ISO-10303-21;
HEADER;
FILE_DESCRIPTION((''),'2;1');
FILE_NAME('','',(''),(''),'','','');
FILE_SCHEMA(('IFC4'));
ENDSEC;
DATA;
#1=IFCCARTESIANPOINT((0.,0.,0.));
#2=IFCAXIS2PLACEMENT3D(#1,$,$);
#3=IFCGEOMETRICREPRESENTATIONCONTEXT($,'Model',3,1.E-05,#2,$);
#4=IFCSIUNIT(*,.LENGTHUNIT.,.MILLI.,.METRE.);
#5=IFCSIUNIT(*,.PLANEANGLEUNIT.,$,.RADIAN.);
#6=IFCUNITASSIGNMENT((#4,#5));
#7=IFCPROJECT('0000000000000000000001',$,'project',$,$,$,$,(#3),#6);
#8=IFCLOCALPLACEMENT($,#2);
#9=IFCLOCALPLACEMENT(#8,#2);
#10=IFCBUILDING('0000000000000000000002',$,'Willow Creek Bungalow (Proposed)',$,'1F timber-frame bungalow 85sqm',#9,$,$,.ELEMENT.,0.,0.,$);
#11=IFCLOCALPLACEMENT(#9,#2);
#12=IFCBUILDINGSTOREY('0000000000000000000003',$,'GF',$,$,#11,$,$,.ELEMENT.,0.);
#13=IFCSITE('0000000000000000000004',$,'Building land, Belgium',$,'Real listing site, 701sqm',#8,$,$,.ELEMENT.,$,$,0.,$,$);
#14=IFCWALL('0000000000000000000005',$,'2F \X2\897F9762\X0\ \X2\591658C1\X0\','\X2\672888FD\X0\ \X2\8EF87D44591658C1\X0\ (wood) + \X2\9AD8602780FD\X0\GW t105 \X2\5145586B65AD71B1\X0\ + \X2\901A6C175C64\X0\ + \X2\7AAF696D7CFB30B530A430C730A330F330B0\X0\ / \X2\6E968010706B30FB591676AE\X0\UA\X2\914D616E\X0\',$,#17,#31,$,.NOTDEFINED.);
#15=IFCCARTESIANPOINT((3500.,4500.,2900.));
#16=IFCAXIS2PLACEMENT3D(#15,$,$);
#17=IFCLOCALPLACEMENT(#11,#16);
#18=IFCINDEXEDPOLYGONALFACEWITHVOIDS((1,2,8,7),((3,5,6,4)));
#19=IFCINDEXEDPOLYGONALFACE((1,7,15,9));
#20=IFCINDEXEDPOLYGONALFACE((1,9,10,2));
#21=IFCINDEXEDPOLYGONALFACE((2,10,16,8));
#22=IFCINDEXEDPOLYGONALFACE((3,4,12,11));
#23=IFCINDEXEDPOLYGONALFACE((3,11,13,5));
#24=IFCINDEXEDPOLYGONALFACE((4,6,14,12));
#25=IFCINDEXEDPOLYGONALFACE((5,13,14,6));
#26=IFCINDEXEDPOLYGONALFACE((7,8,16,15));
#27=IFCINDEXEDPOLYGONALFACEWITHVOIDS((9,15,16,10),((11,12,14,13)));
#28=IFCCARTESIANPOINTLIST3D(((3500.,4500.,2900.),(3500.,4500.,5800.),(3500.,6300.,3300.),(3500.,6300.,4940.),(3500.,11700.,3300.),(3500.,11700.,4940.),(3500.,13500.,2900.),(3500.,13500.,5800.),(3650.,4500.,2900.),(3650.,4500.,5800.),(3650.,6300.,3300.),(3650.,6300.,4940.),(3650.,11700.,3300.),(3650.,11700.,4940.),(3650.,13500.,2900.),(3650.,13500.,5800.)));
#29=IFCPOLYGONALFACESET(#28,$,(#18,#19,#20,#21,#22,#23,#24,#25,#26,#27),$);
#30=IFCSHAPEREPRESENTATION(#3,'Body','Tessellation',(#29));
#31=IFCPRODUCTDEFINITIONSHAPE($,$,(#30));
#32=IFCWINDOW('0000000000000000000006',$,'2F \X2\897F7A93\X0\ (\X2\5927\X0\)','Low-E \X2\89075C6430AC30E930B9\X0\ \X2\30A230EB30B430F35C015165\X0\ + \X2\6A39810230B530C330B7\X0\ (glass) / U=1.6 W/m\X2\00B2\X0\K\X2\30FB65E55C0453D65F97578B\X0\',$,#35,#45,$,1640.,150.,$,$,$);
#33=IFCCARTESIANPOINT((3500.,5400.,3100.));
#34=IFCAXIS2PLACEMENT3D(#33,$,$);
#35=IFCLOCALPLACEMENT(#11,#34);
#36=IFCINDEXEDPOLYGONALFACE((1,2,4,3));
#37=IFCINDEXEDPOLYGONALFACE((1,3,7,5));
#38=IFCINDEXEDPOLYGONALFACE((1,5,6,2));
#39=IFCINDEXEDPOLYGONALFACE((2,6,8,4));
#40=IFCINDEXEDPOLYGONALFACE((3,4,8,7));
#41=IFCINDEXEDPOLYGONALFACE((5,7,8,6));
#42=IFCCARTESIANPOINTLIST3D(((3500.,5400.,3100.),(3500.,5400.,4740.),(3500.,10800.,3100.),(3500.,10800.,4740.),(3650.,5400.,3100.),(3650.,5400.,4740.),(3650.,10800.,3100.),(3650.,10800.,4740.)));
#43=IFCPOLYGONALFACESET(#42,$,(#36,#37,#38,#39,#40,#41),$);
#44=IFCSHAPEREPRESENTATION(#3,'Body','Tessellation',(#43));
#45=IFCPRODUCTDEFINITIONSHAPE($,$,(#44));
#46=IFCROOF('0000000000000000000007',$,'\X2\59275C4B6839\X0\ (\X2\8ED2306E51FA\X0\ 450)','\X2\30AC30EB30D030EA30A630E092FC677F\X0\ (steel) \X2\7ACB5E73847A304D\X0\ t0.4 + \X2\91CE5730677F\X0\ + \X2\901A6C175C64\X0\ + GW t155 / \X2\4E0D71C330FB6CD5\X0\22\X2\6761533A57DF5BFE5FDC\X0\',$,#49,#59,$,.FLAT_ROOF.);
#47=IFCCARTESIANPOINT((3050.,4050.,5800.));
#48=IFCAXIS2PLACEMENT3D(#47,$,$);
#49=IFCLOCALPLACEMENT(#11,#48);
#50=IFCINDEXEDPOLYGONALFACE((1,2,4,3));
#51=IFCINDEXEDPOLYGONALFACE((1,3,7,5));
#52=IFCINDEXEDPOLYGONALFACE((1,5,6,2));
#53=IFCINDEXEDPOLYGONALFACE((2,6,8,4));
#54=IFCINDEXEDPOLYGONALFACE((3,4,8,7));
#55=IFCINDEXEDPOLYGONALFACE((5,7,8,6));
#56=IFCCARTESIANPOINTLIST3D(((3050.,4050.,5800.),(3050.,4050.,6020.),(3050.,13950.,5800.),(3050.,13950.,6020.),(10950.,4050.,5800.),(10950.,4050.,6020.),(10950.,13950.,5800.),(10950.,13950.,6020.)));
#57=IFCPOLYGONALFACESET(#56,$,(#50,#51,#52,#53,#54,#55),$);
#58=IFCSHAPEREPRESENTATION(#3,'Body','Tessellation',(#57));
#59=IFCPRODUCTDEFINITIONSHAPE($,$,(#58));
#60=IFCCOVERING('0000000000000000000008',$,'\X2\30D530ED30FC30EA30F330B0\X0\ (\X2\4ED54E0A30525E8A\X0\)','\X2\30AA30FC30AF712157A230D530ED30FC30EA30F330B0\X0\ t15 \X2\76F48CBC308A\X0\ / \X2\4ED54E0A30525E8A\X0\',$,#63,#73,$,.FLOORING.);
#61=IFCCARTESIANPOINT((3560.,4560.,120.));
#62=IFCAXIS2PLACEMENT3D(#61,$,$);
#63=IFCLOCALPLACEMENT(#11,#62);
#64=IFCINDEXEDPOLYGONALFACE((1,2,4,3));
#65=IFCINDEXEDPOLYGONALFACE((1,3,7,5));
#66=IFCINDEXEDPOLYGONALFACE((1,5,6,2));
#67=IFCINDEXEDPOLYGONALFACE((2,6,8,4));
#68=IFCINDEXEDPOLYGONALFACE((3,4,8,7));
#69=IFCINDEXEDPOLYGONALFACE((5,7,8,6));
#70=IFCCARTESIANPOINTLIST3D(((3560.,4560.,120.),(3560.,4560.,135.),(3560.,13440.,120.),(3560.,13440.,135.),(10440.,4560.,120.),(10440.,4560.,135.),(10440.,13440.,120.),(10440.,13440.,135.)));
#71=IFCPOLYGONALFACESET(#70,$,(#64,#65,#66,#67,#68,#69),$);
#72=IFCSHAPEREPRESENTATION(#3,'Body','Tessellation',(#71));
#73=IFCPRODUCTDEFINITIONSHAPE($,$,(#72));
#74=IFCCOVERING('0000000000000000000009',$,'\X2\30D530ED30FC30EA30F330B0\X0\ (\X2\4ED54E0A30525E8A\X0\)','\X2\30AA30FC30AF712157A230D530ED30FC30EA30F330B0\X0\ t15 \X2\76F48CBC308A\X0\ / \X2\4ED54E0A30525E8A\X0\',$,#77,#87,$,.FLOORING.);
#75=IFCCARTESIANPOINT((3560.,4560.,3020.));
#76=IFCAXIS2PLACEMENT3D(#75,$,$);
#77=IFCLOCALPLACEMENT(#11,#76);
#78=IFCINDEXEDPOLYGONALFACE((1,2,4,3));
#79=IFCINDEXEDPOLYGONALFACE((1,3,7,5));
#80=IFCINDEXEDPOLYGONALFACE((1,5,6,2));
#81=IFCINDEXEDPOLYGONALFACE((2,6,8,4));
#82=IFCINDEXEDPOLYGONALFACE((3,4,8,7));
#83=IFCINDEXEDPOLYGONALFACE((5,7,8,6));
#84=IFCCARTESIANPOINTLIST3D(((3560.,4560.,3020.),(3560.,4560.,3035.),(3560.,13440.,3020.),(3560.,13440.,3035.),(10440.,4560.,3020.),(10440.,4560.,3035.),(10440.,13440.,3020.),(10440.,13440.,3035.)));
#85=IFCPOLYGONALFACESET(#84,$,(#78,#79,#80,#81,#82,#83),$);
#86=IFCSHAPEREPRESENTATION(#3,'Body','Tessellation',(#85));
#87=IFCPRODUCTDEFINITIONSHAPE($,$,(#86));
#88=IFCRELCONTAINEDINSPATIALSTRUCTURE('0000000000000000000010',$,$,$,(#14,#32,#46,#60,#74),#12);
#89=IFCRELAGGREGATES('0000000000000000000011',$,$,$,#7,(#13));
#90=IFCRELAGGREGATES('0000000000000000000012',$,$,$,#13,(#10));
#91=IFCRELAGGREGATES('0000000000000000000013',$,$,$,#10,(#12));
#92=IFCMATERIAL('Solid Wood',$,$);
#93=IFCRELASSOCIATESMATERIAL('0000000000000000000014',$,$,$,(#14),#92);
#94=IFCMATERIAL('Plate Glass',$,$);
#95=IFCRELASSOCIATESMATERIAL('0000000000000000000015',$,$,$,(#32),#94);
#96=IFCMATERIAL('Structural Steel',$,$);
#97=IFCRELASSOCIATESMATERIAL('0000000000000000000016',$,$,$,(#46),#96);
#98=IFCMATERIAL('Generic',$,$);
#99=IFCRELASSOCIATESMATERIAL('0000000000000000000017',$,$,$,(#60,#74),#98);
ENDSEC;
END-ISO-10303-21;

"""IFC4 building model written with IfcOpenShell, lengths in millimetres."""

from ifc_helpers import new_model, si_unit, frame, frame_2d, origin, place, context, project, spatial, rectangle, extrude, material, element, fill, save


model = new_model("IFC4")

# Units and contexts
model_context = context("Model", 3, precision=1e-05, world=origin())
ifc_project = project(units=[si_unit("LENGTHUNIT", "METRE", prefix="MILLI"), si_unit("PLANEANGLEUNIT", "RADIAN")], contexts=[model_context])

# Site, building, storey
site_placement = place(None, origin())
site = spatial("IfcSite", under=ifc_project, at=site_placement, Name="Building land, Belgium", ObjectType="Real listing site, 701sqm", CompositionType="ELEMENT", RefElevation=0.0)
building_placement = place(site_placement, origin())
building = spatial("IfcBuilding", under=site, at=building_placement, Name="Willow Creek Bungalow (Proposed)", ObjectType="1F timber-frame bungalow 85sqm", CompositionType="ELEMENT", ElevationOfRefHeight=0.0, ElevationOfTerrain=0.0)
storey_placement = place(building_placement, origin())
storey = spatial("IfcBuildingStorey", under=building, at=storey_placement, Name="GF", CompositionType="ELEMENT", Elevation=0.0)

# Shared definitions
ifc_material_1 = material(Name="Solid Wood")
ifc_material_2 = material(Name="Generic")

# Shared definitions
ifc_material_3 = material(Name="Plate Glass")

# Wall, opening, window
wall_1_placement = place(storey_placement, frame((3500.0, 4500.0, 2900.0)))
wall_1 = element("IfcWall", 1, at=wall_1_placement, inside=storey, material=ifc_material_1, Name="2F 西面 外壁", Description="木製 軸組外壁 (wood) + 高性能GW t105 充填断熱 + 通気層 + 窯業系サイディング / 準耐火・外皮UA配慮", PredefinedType="NOTDEFINED", context=model_context, shape_type="SweptSolid", body=[
    extrude(rectangle(XDim=150.0, YDim=9000.0, at=frame_2d((75.0, 4500.0))), frame((3500.0, 4500.0, 2900.0)), (0.0, 0.0, 1.0), 2900.0),
])
opening_1_placement = place(storey_placement, frame((3500.0, 5400.0, 3100.0)))
opening_1 = element("IfcOpeningElement", 2, at=opening_1_placement, cuts=wall_1, PredefinedType="NOTDEFINED", context=model_context, shape_type="SweptSolid", body=[
    extrude(rectangle(XDim=150.0, YDim=5400.0, at=frame_2d((75.0, 2700.0))), frame((3500.0, 5400.0, 3100.0)), (0.0, 0.0, 1.0), 1640.0),
])
window_1_placement = place(storey_placement, frame((3500.0, 5400.0, 3100.0)))
window_1 = element("IfcWindow", 3, at=window_1_placement, inside=storey, material=ifc_material_3, Name="2F 西窓 (大)", Description="Low-E 複層ガラス アルゴン封入 + 樹脂サッシ (glass) / U=1.6 W/m²K・日射取得型", OverallHeight=1640.0, OverallWidth=150.0, context=model_context, shape_type="SweptSolid", body=[
    extrude(rectangle(XDim=150.0, YDim=5400.0, at=frame_2d((75.0, 2700.0))), frame((3500.0, 5400.0, 3100.0)), (0.0, 0.0, 1.0), 1640.0),
])
fill(opening_1, window_1)

# Roof
ifc_material_4 = material(Name="Structural Steel")
roof_placement = place(storey_placement, frame((3050.0, 4050.0, 5800.0)))
element("IfcRoof", 4, at=roof_placement, inside=storey, material=ifc_material_4, Name="大屋根 (軒の出 450)", Description="ガルバリウム鋼板 (steel) 立平葺き t0.4 + 野地板 + 通気層 + GW t155 / 不燃・法22条区域対応", PredefinedType="FLAT_ROOF", context=model_context, shape_type="SweptSolid", body=[
    extrude(rectangle(XDim=7900.0, YDim=9900.0, at=frame_2d((3950.0, 4950.0))), frame((3050.0, 4050.0, 5800.0)), (0.0, 0.0, 1.0), 220.0),
])

# Coverings
covering_1_placement = place(storey_placement, frame((3560.0, 4560.0, 120.0)))
element("IfcCovering", 5, at=covering_1_placement, inside=storey, material=ifc_material_2, Name="フローリング (仕上げ床)", Description="オーク無垢フローリング t15 直貼り / 仕上げ床", PredefinedType="FLOORING", context=model_context, shape_type="SweptSolid", body=[
    extrude(rectangle(XDim=6880.0, YDim=8880.0, at=frame_2d((3440.0, 4440.0))), frame((3560.0, 4560.0, 120.0)), (0.0, 0.0, 1.0), 15.0),
])
covering_2_placement = place(storey_placement, frame((3560.0, 4560.0, 3020.0)))
element("IfcCovering", 6, at=covering_2_placement, inside=storey, material=ifc_material_2, Name="フローリング (仕上げ床)", Description="オーク無垢フローリング t15 直貼り / 仕上げ床", PredefinedType="FLOORING", context=model_context, shape_type="SweptSolid", body=[
    extrude(rectangle(XDim=6880.0, YDim=8880.0, at=frame_2d((3440.0, 4440.0))), frame((3560.0, 4560.0, 3020.0)), (0.0, 0.0, 1.0), 15.0),
])

save(model, "model.ifc")
